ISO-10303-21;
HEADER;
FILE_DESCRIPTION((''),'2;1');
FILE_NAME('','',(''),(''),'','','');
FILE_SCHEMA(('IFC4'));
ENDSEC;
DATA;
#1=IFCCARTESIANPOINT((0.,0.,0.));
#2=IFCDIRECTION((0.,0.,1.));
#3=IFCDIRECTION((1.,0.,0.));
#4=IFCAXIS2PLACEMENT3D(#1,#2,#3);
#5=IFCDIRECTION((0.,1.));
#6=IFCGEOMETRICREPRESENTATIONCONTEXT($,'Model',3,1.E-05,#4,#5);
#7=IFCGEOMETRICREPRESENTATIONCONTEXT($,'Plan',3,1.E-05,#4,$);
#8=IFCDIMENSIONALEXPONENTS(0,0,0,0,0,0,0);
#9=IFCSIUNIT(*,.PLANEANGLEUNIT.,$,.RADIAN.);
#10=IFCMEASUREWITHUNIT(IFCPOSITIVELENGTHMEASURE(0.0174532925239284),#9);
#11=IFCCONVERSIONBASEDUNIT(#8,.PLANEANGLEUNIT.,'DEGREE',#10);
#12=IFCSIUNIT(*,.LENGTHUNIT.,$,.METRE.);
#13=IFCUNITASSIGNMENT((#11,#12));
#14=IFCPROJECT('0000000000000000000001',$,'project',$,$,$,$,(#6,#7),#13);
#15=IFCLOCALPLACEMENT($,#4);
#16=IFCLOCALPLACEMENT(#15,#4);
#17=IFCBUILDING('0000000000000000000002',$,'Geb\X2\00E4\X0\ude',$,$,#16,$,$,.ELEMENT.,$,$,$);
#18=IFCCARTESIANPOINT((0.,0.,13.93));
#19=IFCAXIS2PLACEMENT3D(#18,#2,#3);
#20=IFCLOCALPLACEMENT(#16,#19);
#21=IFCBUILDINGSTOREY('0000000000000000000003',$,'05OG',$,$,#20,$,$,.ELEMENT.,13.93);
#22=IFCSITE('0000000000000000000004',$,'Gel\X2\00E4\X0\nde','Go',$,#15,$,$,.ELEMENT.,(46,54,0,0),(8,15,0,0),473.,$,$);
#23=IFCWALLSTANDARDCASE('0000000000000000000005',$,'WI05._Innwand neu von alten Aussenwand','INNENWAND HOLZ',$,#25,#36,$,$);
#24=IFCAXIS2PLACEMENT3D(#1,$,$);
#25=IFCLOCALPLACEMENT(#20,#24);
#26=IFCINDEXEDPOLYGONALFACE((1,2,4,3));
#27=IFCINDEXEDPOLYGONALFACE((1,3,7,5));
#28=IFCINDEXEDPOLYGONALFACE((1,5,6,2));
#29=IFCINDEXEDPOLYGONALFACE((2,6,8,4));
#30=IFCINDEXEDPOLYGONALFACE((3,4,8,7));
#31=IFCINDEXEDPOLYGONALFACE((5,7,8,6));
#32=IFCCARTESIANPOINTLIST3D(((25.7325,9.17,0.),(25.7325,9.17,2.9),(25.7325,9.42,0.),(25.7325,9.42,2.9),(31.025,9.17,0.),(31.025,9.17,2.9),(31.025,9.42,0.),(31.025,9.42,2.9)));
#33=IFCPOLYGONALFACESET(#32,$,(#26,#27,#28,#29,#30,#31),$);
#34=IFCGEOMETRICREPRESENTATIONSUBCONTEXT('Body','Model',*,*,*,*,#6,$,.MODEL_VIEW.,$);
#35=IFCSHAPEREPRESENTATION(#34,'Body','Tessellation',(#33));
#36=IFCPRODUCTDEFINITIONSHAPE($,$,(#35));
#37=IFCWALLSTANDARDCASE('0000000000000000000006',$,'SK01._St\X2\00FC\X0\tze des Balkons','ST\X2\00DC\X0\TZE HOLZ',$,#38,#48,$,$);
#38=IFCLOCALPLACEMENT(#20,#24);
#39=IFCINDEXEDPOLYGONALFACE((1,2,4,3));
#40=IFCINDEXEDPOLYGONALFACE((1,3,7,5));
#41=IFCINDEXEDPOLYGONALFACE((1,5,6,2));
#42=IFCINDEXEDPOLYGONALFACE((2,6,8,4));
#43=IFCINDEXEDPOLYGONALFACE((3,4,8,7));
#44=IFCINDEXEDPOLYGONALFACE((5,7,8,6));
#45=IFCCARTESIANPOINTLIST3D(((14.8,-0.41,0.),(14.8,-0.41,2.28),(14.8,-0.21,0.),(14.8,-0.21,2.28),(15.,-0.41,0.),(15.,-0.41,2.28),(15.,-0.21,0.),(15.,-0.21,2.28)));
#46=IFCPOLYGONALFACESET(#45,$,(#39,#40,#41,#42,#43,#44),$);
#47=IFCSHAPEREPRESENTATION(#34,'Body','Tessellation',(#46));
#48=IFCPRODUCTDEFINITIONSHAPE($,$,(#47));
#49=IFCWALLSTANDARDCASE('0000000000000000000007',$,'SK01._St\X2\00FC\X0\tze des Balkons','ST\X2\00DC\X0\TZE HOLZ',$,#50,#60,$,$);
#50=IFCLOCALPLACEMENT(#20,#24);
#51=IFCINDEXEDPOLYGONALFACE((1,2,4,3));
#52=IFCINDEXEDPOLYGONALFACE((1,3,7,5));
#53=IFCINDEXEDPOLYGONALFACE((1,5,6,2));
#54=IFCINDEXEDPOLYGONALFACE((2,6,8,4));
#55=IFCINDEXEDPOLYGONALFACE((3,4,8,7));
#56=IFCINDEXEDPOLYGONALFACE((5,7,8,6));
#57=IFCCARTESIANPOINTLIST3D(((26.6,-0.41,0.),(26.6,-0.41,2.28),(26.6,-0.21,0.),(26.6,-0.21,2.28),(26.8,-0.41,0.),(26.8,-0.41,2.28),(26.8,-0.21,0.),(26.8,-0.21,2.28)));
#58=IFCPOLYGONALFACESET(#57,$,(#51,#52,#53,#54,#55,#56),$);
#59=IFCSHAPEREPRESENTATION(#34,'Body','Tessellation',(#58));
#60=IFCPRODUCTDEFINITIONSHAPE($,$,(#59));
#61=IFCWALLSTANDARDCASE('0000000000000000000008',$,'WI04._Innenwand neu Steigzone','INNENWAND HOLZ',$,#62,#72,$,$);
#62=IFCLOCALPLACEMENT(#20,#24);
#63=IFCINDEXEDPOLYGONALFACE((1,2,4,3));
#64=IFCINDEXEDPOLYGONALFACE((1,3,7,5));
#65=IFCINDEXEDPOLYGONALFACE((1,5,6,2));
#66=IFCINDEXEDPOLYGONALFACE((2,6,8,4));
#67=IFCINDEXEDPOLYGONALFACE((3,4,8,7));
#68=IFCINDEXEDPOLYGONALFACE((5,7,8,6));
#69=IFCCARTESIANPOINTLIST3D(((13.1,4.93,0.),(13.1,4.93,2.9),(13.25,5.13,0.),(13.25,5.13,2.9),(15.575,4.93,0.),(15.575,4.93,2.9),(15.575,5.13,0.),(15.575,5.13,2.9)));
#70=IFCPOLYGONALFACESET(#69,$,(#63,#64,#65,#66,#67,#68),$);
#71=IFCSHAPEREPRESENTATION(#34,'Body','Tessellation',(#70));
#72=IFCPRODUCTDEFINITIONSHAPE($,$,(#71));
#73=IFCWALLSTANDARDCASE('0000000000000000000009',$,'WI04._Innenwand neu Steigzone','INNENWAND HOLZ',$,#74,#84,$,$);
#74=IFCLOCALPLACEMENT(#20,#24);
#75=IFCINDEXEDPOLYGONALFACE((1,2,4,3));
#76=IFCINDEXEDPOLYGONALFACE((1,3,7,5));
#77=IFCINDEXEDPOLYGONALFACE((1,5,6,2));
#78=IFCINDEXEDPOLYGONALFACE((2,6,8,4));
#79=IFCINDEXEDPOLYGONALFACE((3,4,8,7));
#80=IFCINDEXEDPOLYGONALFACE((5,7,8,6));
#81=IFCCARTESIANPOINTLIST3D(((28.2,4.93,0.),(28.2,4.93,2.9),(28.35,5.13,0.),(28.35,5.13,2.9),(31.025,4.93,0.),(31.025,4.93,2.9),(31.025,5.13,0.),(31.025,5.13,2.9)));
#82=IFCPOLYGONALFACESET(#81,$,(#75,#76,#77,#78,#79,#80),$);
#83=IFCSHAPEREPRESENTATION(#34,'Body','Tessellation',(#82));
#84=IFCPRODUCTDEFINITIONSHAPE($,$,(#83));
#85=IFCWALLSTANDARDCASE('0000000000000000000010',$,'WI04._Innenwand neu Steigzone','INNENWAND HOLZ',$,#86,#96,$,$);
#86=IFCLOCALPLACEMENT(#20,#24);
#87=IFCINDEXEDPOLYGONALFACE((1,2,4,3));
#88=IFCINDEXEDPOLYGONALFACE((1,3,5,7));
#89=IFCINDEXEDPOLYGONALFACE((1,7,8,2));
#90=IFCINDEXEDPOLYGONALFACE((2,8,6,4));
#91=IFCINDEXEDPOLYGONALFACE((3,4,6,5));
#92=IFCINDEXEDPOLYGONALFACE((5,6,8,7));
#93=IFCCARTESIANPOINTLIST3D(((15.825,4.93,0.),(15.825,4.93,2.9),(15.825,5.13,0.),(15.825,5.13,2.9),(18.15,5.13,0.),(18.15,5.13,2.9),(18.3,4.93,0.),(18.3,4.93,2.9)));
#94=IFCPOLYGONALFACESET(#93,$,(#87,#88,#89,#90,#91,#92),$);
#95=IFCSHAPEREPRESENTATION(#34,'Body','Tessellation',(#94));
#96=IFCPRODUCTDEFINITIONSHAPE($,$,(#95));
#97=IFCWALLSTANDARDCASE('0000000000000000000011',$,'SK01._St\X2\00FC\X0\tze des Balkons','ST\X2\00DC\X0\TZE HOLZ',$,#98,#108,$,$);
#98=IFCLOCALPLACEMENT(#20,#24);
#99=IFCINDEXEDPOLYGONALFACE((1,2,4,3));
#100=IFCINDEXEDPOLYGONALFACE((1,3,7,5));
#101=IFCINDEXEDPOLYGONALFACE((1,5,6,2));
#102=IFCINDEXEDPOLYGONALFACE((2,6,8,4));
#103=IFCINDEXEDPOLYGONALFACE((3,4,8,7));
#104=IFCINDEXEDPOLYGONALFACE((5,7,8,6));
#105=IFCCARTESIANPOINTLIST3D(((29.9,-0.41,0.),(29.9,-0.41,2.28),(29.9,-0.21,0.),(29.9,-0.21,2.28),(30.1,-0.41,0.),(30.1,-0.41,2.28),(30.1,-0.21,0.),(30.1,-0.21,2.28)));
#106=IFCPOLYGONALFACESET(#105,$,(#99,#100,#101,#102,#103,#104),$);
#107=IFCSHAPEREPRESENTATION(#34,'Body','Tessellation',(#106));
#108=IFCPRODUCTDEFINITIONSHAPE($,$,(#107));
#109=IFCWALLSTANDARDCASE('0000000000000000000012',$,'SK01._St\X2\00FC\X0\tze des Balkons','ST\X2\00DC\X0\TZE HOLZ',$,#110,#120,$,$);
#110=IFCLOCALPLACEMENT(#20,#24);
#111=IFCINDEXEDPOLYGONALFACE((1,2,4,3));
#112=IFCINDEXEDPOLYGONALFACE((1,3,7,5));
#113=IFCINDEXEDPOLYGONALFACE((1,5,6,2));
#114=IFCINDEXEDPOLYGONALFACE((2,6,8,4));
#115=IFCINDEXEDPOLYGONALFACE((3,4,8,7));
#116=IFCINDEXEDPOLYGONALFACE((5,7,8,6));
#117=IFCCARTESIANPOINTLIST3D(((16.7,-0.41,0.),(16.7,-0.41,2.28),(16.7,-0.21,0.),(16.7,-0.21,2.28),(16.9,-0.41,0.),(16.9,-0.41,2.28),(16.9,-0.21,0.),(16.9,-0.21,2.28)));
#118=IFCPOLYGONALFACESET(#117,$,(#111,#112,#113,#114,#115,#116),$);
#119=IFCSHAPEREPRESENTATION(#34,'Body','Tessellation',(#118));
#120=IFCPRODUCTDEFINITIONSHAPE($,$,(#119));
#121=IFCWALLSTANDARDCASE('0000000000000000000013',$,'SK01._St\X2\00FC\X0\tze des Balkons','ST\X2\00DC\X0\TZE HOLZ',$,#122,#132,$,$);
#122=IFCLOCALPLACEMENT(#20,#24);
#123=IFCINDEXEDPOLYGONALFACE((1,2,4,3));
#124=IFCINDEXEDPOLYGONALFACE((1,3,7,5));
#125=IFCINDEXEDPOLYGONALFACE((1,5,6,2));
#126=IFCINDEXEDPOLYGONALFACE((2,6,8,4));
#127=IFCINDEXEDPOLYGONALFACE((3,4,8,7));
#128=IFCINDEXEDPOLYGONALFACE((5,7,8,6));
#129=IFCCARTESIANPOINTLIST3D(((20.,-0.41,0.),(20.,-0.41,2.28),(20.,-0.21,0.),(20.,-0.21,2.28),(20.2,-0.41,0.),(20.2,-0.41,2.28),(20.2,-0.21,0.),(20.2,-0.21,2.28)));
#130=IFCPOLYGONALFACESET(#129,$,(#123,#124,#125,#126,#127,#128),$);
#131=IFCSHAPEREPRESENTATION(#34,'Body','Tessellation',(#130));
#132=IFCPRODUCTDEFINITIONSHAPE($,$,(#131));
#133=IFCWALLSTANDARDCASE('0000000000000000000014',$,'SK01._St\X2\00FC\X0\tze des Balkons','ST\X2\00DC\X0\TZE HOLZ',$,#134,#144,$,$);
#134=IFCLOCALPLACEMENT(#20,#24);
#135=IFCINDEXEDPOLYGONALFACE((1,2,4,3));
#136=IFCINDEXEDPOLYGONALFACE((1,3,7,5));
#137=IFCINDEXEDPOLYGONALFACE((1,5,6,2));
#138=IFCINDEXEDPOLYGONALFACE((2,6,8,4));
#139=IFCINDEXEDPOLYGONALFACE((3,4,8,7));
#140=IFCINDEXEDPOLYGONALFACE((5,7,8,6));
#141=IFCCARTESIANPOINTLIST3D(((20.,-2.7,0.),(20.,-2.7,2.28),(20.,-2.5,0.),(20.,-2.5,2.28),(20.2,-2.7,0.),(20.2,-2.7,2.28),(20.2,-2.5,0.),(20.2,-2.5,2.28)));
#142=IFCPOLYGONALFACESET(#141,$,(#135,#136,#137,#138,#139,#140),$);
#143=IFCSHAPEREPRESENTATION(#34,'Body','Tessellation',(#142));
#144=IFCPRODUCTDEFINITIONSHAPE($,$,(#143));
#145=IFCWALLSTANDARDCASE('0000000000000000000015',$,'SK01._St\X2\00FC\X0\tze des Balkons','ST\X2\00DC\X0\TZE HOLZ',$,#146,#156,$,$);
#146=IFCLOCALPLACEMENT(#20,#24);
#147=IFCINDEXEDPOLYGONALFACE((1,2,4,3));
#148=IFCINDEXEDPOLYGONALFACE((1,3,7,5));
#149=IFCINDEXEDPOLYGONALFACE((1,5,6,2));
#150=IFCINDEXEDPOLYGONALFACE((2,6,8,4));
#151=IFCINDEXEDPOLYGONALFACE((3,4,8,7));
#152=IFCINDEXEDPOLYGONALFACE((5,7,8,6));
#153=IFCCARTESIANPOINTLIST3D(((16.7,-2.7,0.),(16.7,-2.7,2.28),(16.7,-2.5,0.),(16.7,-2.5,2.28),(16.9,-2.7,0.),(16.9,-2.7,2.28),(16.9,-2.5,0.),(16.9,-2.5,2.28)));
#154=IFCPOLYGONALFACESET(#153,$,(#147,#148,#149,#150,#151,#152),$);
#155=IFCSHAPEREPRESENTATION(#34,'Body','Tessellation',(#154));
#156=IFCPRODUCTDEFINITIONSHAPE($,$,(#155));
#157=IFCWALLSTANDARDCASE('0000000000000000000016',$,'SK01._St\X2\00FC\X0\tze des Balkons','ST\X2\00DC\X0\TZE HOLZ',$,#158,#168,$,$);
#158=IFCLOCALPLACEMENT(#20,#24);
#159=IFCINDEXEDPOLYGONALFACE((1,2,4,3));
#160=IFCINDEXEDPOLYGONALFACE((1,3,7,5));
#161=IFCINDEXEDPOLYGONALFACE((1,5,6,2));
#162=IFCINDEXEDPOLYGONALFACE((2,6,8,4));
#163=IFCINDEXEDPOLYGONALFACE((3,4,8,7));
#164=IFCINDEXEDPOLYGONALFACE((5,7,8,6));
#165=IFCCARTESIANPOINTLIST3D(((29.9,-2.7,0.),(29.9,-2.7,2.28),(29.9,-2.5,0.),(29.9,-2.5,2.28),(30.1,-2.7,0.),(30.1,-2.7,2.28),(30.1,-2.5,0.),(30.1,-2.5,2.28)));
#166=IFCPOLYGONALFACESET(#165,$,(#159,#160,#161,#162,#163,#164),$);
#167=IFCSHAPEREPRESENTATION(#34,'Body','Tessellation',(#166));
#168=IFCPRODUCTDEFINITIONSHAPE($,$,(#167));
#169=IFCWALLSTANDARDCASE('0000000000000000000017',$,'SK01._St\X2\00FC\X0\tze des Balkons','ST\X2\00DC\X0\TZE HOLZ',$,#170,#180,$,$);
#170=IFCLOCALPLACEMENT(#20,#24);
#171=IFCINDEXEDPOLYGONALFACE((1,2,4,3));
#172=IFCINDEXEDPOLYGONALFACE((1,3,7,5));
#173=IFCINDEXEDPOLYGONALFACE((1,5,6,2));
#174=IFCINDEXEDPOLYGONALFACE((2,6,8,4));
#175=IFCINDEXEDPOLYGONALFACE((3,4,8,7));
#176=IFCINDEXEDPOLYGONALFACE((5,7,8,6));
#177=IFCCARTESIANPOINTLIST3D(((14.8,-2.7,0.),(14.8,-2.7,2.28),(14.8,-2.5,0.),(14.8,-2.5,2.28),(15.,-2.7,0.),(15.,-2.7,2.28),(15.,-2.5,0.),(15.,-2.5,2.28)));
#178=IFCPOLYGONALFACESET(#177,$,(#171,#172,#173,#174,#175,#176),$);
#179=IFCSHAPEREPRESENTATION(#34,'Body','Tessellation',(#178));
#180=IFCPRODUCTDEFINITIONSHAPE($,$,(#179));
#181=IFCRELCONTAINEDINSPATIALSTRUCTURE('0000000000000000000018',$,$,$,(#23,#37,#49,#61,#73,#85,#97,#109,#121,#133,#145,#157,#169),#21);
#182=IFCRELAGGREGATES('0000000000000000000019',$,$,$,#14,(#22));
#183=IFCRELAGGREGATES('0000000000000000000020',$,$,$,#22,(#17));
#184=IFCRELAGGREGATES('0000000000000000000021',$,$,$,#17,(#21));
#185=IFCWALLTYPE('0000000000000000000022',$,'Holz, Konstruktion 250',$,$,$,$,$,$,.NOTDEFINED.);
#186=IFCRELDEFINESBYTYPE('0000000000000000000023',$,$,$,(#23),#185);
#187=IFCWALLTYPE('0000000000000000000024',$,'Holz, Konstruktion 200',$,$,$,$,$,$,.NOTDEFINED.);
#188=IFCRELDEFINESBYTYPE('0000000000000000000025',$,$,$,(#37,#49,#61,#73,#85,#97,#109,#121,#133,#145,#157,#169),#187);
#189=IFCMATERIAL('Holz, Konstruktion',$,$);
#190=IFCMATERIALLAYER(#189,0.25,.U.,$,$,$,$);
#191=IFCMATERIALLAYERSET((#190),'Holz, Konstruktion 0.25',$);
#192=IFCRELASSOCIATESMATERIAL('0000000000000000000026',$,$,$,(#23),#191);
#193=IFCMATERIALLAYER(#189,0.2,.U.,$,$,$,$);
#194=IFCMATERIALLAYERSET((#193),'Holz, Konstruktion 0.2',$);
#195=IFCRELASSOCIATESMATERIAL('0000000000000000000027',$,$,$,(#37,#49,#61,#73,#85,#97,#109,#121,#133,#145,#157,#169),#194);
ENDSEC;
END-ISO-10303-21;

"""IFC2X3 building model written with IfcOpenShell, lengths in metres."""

from ifc_helpers import new_model, entity, si_unit, converted_unit, direction, frame, origin_with_axes, place, context, subcontext, project, spatial, polyline, outline, extrude, material, layer, layer_set, layer_usage, type_object, element, save


model = new_model("IFC2X3")

# Units and contexts
model_context = context("Model", 3, precision=1e-05, world=origin_with_axes(), true_north=direction((0.0, 1.0)))
plan_context = context("Plan", 3, precision=1e-05, world=origin_with_axes())
body_context = subcontext(model_context, "Body", "Model", "MODEL_VIEW")
ifc_project = project(units=[converted_unit("PLANEANGLEUNIT", "DEGREE", entity("IfcPositiveLengthMeasure", 0.0174532925239284), si_unit("PLANEANGLEUNIT", "RADIAN"), dimensions=[0, 0, 0, 0, 0, 0, 0]), si_unit("LENGTHUNIT", "METRE")], contexts=[model_context, plan_context])

# Site, building, storey
site_placement = place(None, origin_with_axes())
site = spatial("IfcSite", under=ifc_project, at=site_placement, Name="Gelände", Description="Go", CompositionType="ELEMENT", RefLatitude=(46, 54, 0, 0), RefLongitude=(8, 15, 0, 0), RefElevation=473.0)
building_placement = place(site_placement, origin_with_axes())
building = spatial("IfcBuilding", under=site, at=building_placement, Name="Gebäude", CompositionType="ELEMENT")
storey_placement = place(building_placement, frame((0.0, 0.0, 13.93), z_axis=(0.0, 0.0, 1.0), x_axis=(1.0, 0.0, 0.0)))
storey = spatial("IfcBuildingStorey", under=building, at=storey_placement, Name="05OG", CompositionType="ELEMENT", Elevation=13.93)

# Shared definitions
ifc_material_1 = material(Name="Holz, Konstruktion")

# Walls
ifc_layer_1 = layer(ifc_material_1, 0.25, ventilated="UNKNOWN")
ifc_layer_set_1 = layer_set([ifc_layer_1], Name="Holz, Konstruktion 0.25")
wall_type_1 = type_object("IfcWallType", Name="Holz, Konstruktion 250", PredefinedType="NOTDEFINED")
ifc_layer_usage_1 = layer_usage(ifc_layer_set_1, "AXIS2", "NEGATIVE", 0.0)
wall_1_placement = place(storey_placement, frame((25.7325, 9.42, 0.0), z_axis=(0.0, 0.0, 1.0), x_axis=(1.0, 0.0, 0.0)))
element("IfcWallStandardCase", 1, at=wall_1_placement, inside=storey, type_object=wall_type_1, material=ifc_layer_usage_1, Name="WI05._Innwand neu von alten Aussenwand", Description="INNENWAND HOLZ", context=body_context, shape_type="SweptSolid", body=[
    extrude(outline(polyline([(0.0, -0.25), (5.2925, -0.25), (5.2925, 0.0), (0.0, 0.0), (0.0, -0.25)])), origin_with_axes(), (0.0, 0.0, 1.0), 2.9),
])
ifc_layer_2 = layer(ifc_material_1, 0.2, ventilated="UNKNOWN")
ifc_layer_set_2 = layer_set([ifc_layer_2], Name="Holz, Konstruktion 0.2")
ifc_layer_usage_2 = layer_usage(ifc_layer_set_2, "AXIS2", "POSITIVE", 0.0)
wall_type_2 = type_object("IfcWallType", Name="Holz, Konstruktion 200", PredefinedType="NOTDEFINED")
wall_2_placement = place(storey_placement, frame((15.0, -0.41, 0.0), z_axis=(0.0, 0.0, 1.0), x_axis=(0.0, 1.0, 0.0)))
element("IfcWallStandardCase", 2, at=wall_2_placement, inside=storey, type_object=wall_type_2, material=ifc_layer_usage_2, Name="SK01._Stütze des Balkons", Description="STÜTZE HOLZ", context=body_context, shape_type="SweptSolid", body=[
    extrude(outline(polyline([(0.0, 0.0), (0.2, 0.0), (0.2, 0.2), (0.0, 0.2), (0.0, 0.0)])), origin_with_axes(), (0.0, 0.0, 1.0), 2.28),
])
ifc_layer_usage_3 = layer_usage(ifc_layer_set_2, "AXIS2", "NEGATIVE", 0.0)
wall_3_placement = place(storey_placement, frame((26.6, -0.41, 0.0), z_axis=(0.0, 0.0, 1.0), x_axis=(0.0, 1.0, 0.0)))
element("IfcWallStandardCase", 3, at=wall_3_placement, inside=storey, type_object=wall_type_2, material=ifc_layer_usage_3, Name="SK01._Stütze des Balkons", Description="STÜTZE HOLZ", context=body_context, shape_type="SweptSolid", body=[
    extrude(outline(polyline([(0.0, -0.2), (0.2, -0.2), (0.2, 0.0), (0.0, 0.0), (0.0, -0.2)])), origin_with_axes(), (0.0, 0.0, 1.0), 2.28),
])
ifc_layer_usage_4 = layer_usage(ifc_layer_set_2, "AXIS2", "POSITIVE", 0.0)
wall_4_placement = place(storey_placement, frame((13.1, 4.93, 0.0), z_axis=(0.0, 0.0, 1.0), x_axis=(1.0, 0.0, 0.0)))
element("IfcWallStandardCase", 4, at=wall_4_placement, inside=storey, type_object=wall_type_2, material=ifc_layer_usage_4, Name="WI04._Innenwand neu Steigzone", Description="INNENWAND HOLZ", context=body_context, shape_type="SweptSolid", body=[
    extrude(outline(polyline([(0.0, 0.0), (2.475, 0.0), (2.475, 0.2), (0.15, 0.2), (0.0, 0.0)])), origin_with_axes(), (0.0, 0.0, 1.0), 2.9),
])
ifc_layer_usage_5 = layer_usage(ifc_layer_set_2, "AXIS2", "POSITIVE", 0.0)
wall_5_placement = place(storey_placement, frame((28.2, 4.93, 0.0), z_axis=(0.0, 0.0, 1.0), x_axis=(1.0, 0.0, 0.0)))
element("IfcWallStandardCase", 5, at=wall_5_placement, inside=storey, type_object=wall_type_2, material=ifc_layer_usage_5, Name="WI04._Innenwand neu Steigzone", Description="INNENWAND HOLZ", context=body_context, shape_type="SweptSolid", body=[
    extrude(outline(polyline([(0.0, 0.0), (2.825, 0.0), (2.825, 0.2), (0.15, 0.2), (0.0, 0.0)])), origin_with_axes(), (0.0, 0.0, 1.0), 2.9),
])
ifc_layer_usage_6 = layer_usage(ifc_layer_set_2, "AXIS2", "NEGATIVE", 0.0)
wall_6_placement = place(storey_placement, frame((18.3, 4.93, 0.0), z_axis=(0.0, 0.0, 1.0), x_axis=(-1.0, 0.0, 0.0)))
element("IfcWallStandardCase", 6, at=wall_6_placement, inside=storey, type_object=wall_type_2, material=ifc_layer_usage_6, Name="WI04._Innenwand neu Steigzone", Description="INNENWAND HOLZ", context=body_context, shape_type="SweptSolid", body=[
    extrude(outline(polyline([(0.15, -0.2), (2.475, -0.2), (2.475, 0.0), (0.0, 0.0), (0.15, -0.2)])), origin_with_axes(), (0.0, 0.0, 1.0), 2.9),
])
ifc_layer_usage_7 = layer_usage(ifc_layer_set_2, "AXIS2", "POSITIVE", 0.0)
wall_7_placement = place(storey_placement, frame((30.1, -0.41, 0.0), z_axis=(0.0, 0.0, 1.0), x_axis=(0.0, 1.0, 0.0)))
element("IfcWallStandardCase", 7, at=wall_7_placement, inside=storey, type_object=wall_type_2, material=ifc_layer_usage_7, Name="SK01._Stütze des Balkons", Description="STÜTZE HOLZ", context=body_context, shape_type="SweptSolid", body=[
    extrude(outline(polyline([(0.0, 0.0), (0.2, 0.0), (0.2, 0.2), (0.0, 0.2), (0.0, 0.0)])), origin_with_axes(), (0.0, 0.0, 1.0), 2.28),
])
ifc_layer_usage_8 = layer_usage(ifc_layer_set_2, "AXIS2", "NEGATIVE", 0.0)
wall_8_placement = place(storey_placement, frame((16.7, -0.41, 0.0), z_axis=(0.0, 0.0, 1.0), x_axis=(0.0, 1.0, 0.0)))
element("IfcWallStandardCase", 8, at=wall_8_placement, inside=storey, type_object=wall_type_2, material=ifc_layer_usage_8, Name="SK01._Stütze des Balkons", Description="STÜTZE HOLZ", context=body_context, shape_type="SweptSolid", body=[
    extrude(outline(polyline([(0.0, -0.2), (0.2, -0.2), (0.2, 0.0), (0.0, 0.0), (0.0, -0.2)])), origin_with_axes(), (0.0, 0.0, 1.0), 2.28),
])
ifc_layer_usage_9 = layer_usage(ifc_layer_set_2, "AXIS2", "POSITIVE", 0.0)
wall_9_placement = place(storey_placement, frame((20.2, -0.41, 0.0), z_axis=(0.0, 0.0, 1.0), x_axis=(0.0, 1.0, 0.0)))
element("IfcWallStandardCase", 9, at=wall_9_placement, inside=storey, type_object=wall_type_2, material=ifc_layer_usage_9, Name="SK01._Stütze des Balkons", Description="STÜTZE HOLZ", context=body_context, shape_type="SweptSolid", body=[
    extrude(outline(polyline([(0.0, 0.0), (0.2, 0.0), (0.2, 0.2), (0.0, 0.2), (0.0, 0.0)])), origin_with_axes(), (0.0, 0.0, 1.0), 2.28),
])
ifc_layer_usage_10 = layer_usage(ifc_layer_set_2, "AXIS2", "POSITIVE", 0.0)
wall_10_placement = place(storey_placement, frame((20.2, -2.7, 0.0), z_axis=(0.0, 0.0, 1.0), x_axis=(0.0, 1.0, 0.0)))
element("IfcWallStandardCase", 10, at=wall_10_placement, inside=storey, type_object=wall_type_2, material=ifc_layer_usage_10, Name="SK01._Stütze des Balkons", Description="STÜTZE HOLZ", context=body_context, shape_type="SweptSolid", body=[
    extrude(outline(polyline([(0.0, 0.0), (0.2, 0.0), (0.2, 0.2), (0.0, 0.2), (0.0, 0.0)])), origin_with_axes(), (0.0, 0.0, 1.0), 2.28),
])
ifc_layer_usage_11 = layer_usage(ifc_layer_set_2, "AXIS2", "NEGATIVE", 0.0)
wall_11_placement = place(storey_placement, frame((16.7, -2.7, 0.0), z_axis=(0.0, 0.0, 1.0), x_axis=(0.0, 1.0, 0.0)))
element("IfcWallStandardCase", 11, at=wall_11_placement, inside=storey, type_object=wall_type_2, material=ifc_layer_usage_11, Name="SK01._Stütze des Balkons", Description="STÜTZE HOLZ", context=body_context, shape_type="SweptSolid", body=[
    extrude(outline(polyline([(0.0, -0.2), (0.2, -0.2), (0.2, 0.0), (0.0, 0.0), (0.0, -0.2)])), origin_with_axes(), (0.0, 0.0, 1.0), 2.28),
])
ifc_layer_usage_12 = layer_usage(ifc_layer_set_2, "AXIS2", "POSITIVE", 0.0)
wall_12_placement = place(storey_placement, frame((30.1, -2.7, 0.0), z_axis=(0.0, 0.0, 1.0), x_axis=(0.0, 1.0, 0.0)))
element("IfcWallStandardCase", 12, at=wall_12_placement, inside=storey, type_object=wall_type_2, material=ifc_layer_usage_12, Name="SK01._Stütze des Balkons", Description="STÜTZE HOLZ", context=body_context, shape_type="SweptSolid", body=[
    extrude(outline(polyline([(0.0, 0.0), (0.2, 0.0), (0.2, 0.2), (0.0, 0.2), (0.0, 0.0)])), origin_with_axes(), (0.0, 0.0, 1.0), 2.28),
])
ifc_layer_usage_13 = layer_usage(ifc_layer_set_2, "AXIS2", "POSITIVE", 0.0)
wall_13_placement = place(storey_placement, frame((15.0, -2.7, 0.0), z_axis=(0.0, 0.0, 1.0), x_axis=(0.0, 1.0, 0.0)))
element("IfcWallStandardCase", 13, at=wall_13_placement, inside=storey, type_object=wall_type_2, material=ifc_layer_usage_13, Name="SK01._Stütze des Balkons", Description="STÜTZE HOLZ", context=body_context, shape_type="SweptSolid", body=[
    extrude(outline(polyline([(0.0, 0.0), (0.2, 0.0), (0.2, 0.2), (0.0, 0.2), (0.0, 0.0)])), origin_with_axes(), (0.0, 0.0, 1.0), 2.28),
])

save(model, "model.ifc")
